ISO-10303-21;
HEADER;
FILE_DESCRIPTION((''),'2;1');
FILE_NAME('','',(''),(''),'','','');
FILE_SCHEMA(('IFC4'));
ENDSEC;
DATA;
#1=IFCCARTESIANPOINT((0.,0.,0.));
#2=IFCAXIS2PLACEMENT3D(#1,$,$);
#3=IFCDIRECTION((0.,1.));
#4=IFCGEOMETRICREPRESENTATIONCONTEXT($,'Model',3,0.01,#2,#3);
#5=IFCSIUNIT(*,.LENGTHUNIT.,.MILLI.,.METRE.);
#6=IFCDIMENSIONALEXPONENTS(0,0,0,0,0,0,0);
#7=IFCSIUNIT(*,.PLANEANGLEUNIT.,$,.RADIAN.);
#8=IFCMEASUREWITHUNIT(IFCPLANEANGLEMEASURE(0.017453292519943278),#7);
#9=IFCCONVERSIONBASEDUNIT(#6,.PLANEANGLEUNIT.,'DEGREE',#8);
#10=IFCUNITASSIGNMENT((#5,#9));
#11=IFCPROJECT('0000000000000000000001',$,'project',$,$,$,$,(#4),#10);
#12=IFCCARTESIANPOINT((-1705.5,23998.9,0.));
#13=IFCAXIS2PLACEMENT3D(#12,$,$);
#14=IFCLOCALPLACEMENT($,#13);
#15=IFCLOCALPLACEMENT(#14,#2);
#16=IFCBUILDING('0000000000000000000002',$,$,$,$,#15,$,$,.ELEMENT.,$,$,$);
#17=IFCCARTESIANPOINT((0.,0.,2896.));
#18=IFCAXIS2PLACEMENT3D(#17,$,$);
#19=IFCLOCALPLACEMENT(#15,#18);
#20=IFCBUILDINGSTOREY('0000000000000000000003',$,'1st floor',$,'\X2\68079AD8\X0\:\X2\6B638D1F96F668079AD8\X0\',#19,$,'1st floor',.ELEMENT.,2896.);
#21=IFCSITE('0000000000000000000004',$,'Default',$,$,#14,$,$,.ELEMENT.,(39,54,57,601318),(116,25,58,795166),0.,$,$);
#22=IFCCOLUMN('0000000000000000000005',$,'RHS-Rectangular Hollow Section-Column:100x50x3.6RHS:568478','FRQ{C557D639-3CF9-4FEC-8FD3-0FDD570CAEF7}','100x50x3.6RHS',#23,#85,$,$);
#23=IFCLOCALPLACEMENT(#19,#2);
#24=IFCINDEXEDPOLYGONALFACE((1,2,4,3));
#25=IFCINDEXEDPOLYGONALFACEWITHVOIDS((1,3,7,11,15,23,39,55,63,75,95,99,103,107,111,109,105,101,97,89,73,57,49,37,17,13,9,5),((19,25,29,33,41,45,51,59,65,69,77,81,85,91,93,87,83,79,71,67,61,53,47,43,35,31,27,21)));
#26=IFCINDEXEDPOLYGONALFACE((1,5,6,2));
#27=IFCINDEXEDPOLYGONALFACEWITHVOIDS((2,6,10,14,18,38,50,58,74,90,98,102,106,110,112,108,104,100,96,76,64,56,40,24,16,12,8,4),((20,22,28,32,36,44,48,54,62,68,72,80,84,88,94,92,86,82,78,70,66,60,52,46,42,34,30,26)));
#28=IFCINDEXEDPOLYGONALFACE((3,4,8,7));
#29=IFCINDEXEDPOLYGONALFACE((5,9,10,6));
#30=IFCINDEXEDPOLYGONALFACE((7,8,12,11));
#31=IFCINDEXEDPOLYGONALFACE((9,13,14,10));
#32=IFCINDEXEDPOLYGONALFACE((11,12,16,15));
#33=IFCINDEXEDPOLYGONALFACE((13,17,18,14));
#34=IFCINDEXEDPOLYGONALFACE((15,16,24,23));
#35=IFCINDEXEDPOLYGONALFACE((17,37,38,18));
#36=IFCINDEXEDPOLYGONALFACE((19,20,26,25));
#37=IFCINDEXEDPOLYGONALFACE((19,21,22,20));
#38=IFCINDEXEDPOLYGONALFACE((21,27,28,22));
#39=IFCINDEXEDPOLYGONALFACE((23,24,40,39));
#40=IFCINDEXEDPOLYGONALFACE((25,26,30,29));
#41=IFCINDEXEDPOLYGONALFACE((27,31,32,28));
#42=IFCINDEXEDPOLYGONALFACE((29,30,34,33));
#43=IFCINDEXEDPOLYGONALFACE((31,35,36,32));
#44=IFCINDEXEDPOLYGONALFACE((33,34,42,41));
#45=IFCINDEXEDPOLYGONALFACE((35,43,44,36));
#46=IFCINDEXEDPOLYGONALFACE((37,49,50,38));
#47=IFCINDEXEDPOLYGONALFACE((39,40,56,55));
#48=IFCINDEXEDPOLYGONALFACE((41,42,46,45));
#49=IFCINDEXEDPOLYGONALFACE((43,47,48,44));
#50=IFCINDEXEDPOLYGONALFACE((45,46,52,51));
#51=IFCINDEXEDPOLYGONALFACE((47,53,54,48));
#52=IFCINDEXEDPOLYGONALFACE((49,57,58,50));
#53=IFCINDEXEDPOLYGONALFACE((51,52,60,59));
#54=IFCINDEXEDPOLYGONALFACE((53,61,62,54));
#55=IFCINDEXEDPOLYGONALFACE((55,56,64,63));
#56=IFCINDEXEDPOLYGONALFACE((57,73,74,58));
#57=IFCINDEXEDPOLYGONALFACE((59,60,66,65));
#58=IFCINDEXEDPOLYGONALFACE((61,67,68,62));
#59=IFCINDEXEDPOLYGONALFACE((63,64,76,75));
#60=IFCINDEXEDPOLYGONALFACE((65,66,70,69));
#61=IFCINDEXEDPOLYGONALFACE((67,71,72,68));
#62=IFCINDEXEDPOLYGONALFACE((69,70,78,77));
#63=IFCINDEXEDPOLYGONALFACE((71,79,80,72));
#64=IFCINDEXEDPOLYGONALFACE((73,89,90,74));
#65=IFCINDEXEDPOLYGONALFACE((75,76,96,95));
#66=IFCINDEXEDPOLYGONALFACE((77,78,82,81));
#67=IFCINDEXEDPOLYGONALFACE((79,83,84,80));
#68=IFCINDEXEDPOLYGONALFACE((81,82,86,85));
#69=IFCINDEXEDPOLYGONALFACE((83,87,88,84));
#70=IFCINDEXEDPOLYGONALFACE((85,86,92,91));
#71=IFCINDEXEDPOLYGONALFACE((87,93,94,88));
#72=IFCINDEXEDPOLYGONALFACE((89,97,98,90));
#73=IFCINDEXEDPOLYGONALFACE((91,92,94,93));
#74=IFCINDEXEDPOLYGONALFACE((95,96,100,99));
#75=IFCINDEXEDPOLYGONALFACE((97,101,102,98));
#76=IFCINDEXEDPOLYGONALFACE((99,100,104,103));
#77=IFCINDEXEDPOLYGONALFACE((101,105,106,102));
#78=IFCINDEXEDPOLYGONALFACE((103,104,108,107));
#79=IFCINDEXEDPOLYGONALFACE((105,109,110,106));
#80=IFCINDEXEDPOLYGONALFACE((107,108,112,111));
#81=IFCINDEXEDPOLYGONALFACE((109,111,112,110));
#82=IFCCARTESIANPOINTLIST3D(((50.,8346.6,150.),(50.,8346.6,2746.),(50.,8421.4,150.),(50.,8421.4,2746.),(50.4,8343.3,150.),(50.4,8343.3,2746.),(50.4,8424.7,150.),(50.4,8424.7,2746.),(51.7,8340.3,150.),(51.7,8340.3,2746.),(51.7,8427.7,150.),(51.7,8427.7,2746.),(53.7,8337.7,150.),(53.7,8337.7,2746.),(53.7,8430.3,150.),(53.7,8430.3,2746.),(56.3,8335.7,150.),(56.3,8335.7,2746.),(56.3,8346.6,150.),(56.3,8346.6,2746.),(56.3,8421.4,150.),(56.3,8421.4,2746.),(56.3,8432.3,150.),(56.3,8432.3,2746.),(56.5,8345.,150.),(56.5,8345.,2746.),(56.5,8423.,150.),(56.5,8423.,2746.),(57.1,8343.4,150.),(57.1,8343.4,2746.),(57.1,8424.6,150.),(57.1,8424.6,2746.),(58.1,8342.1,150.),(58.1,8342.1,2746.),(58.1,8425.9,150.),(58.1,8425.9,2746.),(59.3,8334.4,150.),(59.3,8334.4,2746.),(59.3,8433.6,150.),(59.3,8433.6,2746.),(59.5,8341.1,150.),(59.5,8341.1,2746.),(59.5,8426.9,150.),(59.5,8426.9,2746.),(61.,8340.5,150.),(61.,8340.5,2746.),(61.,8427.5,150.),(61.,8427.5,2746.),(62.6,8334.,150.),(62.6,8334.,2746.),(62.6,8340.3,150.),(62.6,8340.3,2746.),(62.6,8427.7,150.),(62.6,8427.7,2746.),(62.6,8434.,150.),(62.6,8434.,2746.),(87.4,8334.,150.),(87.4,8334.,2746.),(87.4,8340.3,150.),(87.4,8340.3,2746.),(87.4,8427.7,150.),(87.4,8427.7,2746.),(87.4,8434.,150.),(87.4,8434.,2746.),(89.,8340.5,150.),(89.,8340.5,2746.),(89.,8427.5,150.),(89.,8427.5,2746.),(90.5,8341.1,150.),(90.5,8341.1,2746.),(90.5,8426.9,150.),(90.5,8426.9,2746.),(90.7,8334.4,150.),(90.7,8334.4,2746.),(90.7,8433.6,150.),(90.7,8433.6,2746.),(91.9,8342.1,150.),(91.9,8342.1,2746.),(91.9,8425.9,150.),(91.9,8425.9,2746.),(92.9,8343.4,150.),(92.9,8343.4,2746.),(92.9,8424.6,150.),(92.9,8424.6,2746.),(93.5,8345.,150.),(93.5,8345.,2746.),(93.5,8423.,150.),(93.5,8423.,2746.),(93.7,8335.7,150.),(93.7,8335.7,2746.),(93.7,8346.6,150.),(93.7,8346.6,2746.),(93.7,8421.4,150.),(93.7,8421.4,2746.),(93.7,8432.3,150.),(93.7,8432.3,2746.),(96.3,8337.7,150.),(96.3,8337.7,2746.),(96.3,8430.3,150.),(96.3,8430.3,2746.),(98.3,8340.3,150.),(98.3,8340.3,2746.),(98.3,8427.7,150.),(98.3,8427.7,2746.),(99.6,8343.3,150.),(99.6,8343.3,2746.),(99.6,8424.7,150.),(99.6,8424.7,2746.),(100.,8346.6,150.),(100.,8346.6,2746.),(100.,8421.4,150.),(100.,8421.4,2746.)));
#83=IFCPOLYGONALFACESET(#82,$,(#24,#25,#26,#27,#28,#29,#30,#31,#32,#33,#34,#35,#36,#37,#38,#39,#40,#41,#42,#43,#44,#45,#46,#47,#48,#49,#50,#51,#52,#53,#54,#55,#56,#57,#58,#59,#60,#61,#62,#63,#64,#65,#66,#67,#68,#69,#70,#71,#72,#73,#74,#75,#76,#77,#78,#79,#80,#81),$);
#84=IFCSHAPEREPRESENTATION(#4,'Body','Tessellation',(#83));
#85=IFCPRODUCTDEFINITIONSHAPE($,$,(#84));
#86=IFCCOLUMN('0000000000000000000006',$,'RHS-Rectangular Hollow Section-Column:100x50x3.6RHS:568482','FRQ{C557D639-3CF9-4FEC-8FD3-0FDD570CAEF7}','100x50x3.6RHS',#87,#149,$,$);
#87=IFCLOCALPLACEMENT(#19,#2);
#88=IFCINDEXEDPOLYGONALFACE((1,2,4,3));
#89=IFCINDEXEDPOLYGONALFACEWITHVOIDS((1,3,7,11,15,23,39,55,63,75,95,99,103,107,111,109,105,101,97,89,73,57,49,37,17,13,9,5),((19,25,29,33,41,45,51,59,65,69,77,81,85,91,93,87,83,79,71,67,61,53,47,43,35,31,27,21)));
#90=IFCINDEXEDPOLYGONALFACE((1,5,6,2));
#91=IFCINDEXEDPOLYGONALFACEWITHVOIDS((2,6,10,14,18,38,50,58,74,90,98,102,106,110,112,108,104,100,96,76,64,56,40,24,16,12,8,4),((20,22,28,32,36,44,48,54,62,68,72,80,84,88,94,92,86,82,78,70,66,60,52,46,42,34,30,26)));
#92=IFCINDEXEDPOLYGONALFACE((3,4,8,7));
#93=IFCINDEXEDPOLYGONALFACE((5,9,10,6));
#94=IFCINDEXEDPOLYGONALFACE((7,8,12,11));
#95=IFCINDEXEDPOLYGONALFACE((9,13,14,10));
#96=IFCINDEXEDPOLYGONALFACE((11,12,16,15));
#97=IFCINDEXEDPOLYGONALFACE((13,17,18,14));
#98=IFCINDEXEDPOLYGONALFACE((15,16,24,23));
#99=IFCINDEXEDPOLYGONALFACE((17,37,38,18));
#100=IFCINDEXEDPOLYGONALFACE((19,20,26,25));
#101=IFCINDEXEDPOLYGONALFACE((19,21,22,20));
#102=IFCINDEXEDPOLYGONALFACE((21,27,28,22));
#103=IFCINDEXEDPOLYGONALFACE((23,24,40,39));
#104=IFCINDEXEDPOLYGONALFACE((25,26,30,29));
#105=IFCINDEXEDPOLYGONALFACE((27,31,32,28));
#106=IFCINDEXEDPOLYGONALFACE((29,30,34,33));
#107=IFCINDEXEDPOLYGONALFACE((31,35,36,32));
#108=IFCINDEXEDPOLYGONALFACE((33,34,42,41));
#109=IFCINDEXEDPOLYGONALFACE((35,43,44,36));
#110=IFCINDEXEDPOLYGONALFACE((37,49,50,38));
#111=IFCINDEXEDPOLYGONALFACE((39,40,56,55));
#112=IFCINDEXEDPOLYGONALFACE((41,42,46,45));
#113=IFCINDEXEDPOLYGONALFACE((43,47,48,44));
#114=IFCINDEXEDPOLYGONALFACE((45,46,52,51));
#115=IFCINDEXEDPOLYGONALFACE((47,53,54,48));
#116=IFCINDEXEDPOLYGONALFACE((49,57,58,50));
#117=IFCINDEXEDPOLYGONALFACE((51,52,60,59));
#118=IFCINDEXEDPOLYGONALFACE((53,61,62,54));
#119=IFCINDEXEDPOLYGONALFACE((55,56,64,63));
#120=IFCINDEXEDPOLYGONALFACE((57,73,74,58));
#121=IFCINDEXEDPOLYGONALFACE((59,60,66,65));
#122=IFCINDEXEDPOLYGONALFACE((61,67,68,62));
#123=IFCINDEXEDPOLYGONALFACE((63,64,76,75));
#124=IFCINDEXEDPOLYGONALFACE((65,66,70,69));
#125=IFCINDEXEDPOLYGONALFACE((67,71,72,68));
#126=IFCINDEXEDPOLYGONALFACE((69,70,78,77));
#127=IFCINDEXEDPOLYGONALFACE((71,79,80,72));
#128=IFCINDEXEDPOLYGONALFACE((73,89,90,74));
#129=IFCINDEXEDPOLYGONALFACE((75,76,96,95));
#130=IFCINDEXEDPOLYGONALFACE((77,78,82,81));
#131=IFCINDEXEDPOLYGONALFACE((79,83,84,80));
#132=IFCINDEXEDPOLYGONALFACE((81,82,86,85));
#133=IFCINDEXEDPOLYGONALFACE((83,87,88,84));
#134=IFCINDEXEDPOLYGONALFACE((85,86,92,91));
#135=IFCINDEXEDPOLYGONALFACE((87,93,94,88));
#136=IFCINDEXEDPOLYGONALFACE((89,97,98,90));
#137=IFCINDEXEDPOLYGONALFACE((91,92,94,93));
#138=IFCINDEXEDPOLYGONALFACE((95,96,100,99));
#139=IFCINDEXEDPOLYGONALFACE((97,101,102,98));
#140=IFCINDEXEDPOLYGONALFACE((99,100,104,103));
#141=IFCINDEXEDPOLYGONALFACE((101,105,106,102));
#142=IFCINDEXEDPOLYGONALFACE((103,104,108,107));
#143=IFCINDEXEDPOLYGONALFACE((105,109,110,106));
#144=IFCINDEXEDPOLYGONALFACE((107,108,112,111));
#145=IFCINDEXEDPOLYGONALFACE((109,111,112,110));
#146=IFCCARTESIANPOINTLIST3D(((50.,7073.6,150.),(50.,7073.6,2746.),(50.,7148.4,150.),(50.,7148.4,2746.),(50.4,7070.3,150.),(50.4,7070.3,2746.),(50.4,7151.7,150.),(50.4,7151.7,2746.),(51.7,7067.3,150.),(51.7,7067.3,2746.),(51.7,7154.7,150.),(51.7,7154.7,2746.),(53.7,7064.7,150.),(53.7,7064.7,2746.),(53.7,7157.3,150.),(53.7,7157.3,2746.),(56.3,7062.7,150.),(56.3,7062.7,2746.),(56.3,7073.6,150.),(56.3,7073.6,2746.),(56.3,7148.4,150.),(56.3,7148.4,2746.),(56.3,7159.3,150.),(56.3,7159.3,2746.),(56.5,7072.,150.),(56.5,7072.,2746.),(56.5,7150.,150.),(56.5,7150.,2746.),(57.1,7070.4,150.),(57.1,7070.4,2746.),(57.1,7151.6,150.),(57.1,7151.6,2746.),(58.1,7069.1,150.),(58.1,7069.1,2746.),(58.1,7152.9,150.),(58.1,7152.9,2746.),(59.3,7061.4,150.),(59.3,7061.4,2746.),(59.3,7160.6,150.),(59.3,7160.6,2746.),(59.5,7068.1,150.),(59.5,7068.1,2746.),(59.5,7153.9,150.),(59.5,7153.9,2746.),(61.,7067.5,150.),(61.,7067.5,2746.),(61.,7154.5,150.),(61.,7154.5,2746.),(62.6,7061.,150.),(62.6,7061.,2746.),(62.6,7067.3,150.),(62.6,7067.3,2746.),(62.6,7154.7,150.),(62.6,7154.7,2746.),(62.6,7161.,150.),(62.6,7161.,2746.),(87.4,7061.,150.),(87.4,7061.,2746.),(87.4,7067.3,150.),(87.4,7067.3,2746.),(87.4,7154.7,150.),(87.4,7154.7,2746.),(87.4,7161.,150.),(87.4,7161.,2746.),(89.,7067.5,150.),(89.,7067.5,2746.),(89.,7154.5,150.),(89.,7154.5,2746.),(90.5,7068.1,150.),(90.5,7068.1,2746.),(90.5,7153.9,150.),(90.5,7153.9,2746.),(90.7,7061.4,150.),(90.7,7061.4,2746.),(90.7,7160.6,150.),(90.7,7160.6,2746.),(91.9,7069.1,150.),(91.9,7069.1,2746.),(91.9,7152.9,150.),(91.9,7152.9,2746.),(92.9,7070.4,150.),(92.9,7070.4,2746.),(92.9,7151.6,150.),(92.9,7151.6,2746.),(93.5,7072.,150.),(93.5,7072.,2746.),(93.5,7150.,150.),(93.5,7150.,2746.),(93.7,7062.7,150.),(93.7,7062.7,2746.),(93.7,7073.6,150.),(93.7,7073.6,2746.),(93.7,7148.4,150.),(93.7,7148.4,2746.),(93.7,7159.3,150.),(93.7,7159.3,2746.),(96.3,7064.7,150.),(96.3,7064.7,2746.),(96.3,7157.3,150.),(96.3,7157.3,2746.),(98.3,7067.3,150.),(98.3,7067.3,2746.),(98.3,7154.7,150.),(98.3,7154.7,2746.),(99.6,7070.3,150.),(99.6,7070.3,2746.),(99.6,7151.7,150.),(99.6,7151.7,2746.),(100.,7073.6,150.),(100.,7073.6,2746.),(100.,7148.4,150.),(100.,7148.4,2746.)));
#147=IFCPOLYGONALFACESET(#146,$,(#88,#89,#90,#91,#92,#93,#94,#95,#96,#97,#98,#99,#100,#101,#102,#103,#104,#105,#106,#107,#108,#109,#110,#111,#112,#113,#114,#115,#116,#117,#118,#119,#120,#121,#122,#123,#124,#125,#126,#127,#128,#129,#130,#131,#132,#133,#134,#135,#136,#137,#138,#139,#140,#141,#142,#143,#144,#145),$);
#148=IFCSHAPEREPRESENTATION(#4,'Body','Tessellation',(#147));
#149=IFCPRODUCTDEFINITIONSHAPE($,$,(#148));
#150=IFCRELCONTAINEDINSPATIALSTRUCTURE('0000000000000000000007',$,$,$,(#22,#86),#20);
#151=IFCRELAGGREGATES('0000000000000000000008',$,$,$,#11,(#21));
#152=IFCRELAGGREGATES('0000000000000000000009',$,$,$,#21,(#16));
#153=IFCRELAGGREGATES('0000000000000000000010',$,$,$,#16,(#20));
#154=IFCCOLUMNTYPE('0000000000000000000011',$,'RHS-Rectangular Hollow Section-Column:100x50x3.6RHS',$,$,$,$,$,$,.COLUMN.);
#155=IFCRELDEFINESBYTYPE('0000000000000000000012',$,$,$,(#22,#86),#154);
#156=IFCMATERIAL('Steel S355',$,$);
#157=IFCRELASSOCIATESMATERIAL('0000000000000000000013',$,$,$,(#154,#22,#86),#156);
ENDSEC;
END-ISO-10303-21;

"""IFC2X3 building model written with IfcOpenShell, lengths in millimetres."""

from ifc_helpers import new_model, entity, si_unit, converted_unit, point, direction, frame, frame_2d, origin, origin_2d, place, context, project, spatial, circle_curve, line_curve, trimmed, segment, composite_curve, hollow_rectangle, outline, extrude, clip, halfspace, material, type_object, element, save


model = new_model("IFC2X3")

# Units and contexts
model_context = context("Model", 3, precision=0.01, world=origin(), true_north=direction((0.0, 1.0)))
ifc_project = project(units=[si_unit("LENGTHUNIT", "METRE", prefix="MILLI"), converted_unit("PLANEANGLEUNIT", "DEGREE", entity("IfcPlaneAngleMeasure", 0.017453292519943278), si_unit("PLANEANGLEUNIT", "RADIAN"), dimensions=[0, 0, 0, 0, 0, 0, 0])], contexts=[model_context])

# Site, building, storey
site_placement = place(None, frame((-1705.5, 23998.9, 0.0)))
site = spatial("IfcSite", under=ifc_project, at=site_placement, Name="Default", CompositionType="ELEMENT", RefLatitude=(39, 54, 57, 601318), RefLongitude=(116, 25, 58, 795166), RefElevation=0.0)
building_placement = place(site_placement, origin())
building = spatial("IfcBuilding", under=site, at=building_placement, CompositionType="ELEMENT")
storey_placement = place(building_placement, frame((0.0, 0.0, 2896.0)))
storey = spatial("IfcBuildingStorey", under=building, at=storey_placement, Name="1st floor", ObjectType="标高:正负零标高", LongName="1st floor", CompositionType="ELEMENT", Elevation=2896.0)

# Columns, openings
ifc_material_1 = material(Name="Steel S355")
column_type = type_object("IfcColumnType", Name="RHS-Rectangular Hollow Section-Column:100x50x3.6RHS", PredefinedType="COLUMN", material=ifc_material_1)
column_1_placement = place(storey_placement, frame((75.0, 8384.0, 2876.9)))
column_1 = element("IfcColumn", 1, at=column_1_placement, inside=storey, type_object=column_type, material=ifc_material_1, Name="RHS-Rectangular Hollow Section-Column:100x50x3.6RHS:568478", Description="FRQ{C557D639-3CF9-4FEC-8FD3-0FDD570CAEF7}", ObjectType="100x50x3.6RHS", context=model_context, shape_type="Clipping", body=[
    clip(clip(extrude(hollow_rectangle(XDim=50.0, YDim=100.0, WallThickness=6.3, InnerFilletRadius=6.3, OuterFilletRadius=12.6, at=origin_2d()), origin(), (0.0, 0.0, -1.0), 2782.8), halfspace(frame((-75.0, -8384.0, -55.9), z_axis=(0.0, 0.0, -1.0), x_axis=(-1.0, 0.0, 0.0)), True)), halfspace(frame((-75.0, -8384.0, -2726.9), z_axis=(0.0, 0.0, 1.0), x_axis=(1.0, 0.0, 0.0)), True)),
])
opening_1_placement = place(column_1_placement, frame((0.0, -150.1, -130.9), z_axis=(0.0, 1.0, 0.0), x_axis=(-1.0, 0.0, 0.0)))
element("IfcOpeningElement", 2, at=opening_1_placement, cuts=column_1, ObjectType="Opening", context=model_context, shape_type="SweptSolid", body=[
    extrude(outline(composite_curve([segment(trimmed(circle_curve(frame_2d((43.0, 32.0), x_axis=(1.0, 0.0)), 32.0), [point((43.0, 0.0))], [point((75.0, 32.0))], True, "CARTESIAN"), True, "CONTINUOUS"), segment(trimmed(line_curve((75.0, 32.0), (0.0, 1.0), 86.0), [point((75.0, 32.0))], [point((75.0, 118.0))], True, "CARTESIAN"), True, "CONTINUOUS"), segment(trimmed(circle_curve(frame_2d((43.0, 118.0), x_axis=(1.0, 0.0)), 32.0), [point((75.0, 118.0))], [point((43.0, 150.0))], True, "CARTESIAN"), True, "CONTINUOUS"), segment(trimmed(line_curve((43.0, 150.0), (-1.0, 0.0), 86.0), [point((43.0, 150.0))], [point((-43.0, 150.0))], True, "CARTESIAN"), True, "CONTINUOUS"), segment(trimmed(circle_curve(frame_2d((-43.0, 118.0), x_axis=(1.0, 0.0)), 32.0), [point((-43.0, 150.0))], [point((-75.0, 118.0))], True, "CARTESIAN"), True, "CONTINUOUS"), segment(trimmed(line_curve((-75.0, 118.0), (0.0, -1.0), 86.0), [point((-75.0, 118.0))], [point((-75.0, 32.0))], True, "CARTESIAN"), True, "CONTINUOUS"), segment(trimmed(circle_curve(frame_2d((-43.0, 32.0), x_axis=(1.0, 0.0)), 32.0), [point((-75.0, 32.0))], [point((-43.0, 0.0))], True, "CARTESIAN"), True, "CONTINUOUS"), segment(trimmed(line_curve((-43.0, 0.0), (1.0, 0.0), 86.0), [point((-43.0, 0.0))], [point((43.0, 0.0))], True, "CARTESIAN"), True, "CONTINUOUS")], self_intersect="UNKNOWN")), origin(), (0.0, 0.0, 1.0), 300.2),
])
column_2_placement = place(storey_placement, frame((75.0, 7111.0, 2876.9)))
column_2 = element("IfcColumn", 3, at=column_2_placement, inside=storey, type_object=column_type, material=ifc_material_1, Name="RHS-Rectangular Hollow Section-Column:100x50x3.6RHS:568482", Description="FRQ{C557D639-3CF9-4FEC-8FD3-0FDD570CAEF7}", ObjectType="100x50x3.6RHS", context=model_context, shape_type="Clipping", body=[
    clip(clip(extrude(hollow_rectangle(XDim=50.0, YDim=100.0, WallThickness=6.3, InnerFilletRadius=6.3, OuterFilletRadius=12.6, at=origin_2d()), origin(), (0.0, 0.0, -1.0), 2782.8), halfspace(frame((-75.0, -7111.0, -55.9), z_axis=(0.0, 0.0, -1.0), x_axis=(-1.0, 0.0, 0.0)), True)), halfspace(frame((-75.0, -7111.0, -2726.9), z_axis=(0.0, 0.0, 1.0), x_axis=(1.0, 0.0, 0.0)), True)),
])
opening_2_placement = place(column_2_placement, frame((0.0, -150.1, -130.9), z_axis=(0.0, 1.0, 0.0), x_axis=(-1.0, 0.0, 0.0)))
element("IfcOpeningElement", 4, at=opening_2_placement, cuts=column_2, ObjectType="Opening", context=model_context, shape_type="SweptSolid", body=[
    extrude(outline(composite_curve([segment(trimmed(circle_curve(frame_2d((43.0, 32.0), x_axis=(1.0, 0.0)), 32.0), [point((43.0, 0.0))], [point((75.0, 32.0))], True, "CARTESIAN"), True, "CONTINUOUS"), segment(trimmed(line_curve((75.0, 32.0), (0.0, 1.0), 86.0), [point((75.0, 32.0))], [point((75.0, 118.0))], True, "CARTESIAN"), True, "CONTINUOUS"), segment(trimmed(circle_curve(frame_2d((43.0, 118.0), x_axis=(1.0, 0.0)), 32.0), [point((75.0, 118.0))], [point((43.0, 150.0))], True, "CARTESIAN"), True, "CONTINUOUS"), segment(trimmed(line_curve((43.0, 150.0), (-1.0, 0.0), 86.0), [point((43.0, 150.0))], [point((-43.0, 150.0))], True, "CARTESIAN"), True, "CONTINUOUS"), segment(trimmed(circle_curve(frame_2d((-43.0, 118.0), x_axis=(1.0, 0.0)), 32.0), [point((-43.0, 150.0))], [point((-75.0, 118.0))], True, "CARTESIAN"), True, "CONTINUOUS"), segment(trimmed(line_curve((-75.0, 118.0), (0.0, -1.0), 86.0), [point((-75.0, 118.0))], [point((-75.0, 32.0))], True, "CARTESIAN"), True, "CONTINUOUS"), segment(trimmed(circle_curve(frame_2d((-43.0, 32.0), x_axis=(1.0, 0.0)), 32.0), [point((-75.0, 32.0))], [point((-43.0, 0.0))], True, "CARTESIAN"), True, "CONTINUOUS"), segment(trimmed(line_curve((-43.0, 0.0), (1.0, 0.0), 86.0), [point((-43.0, 0.0))], [point((43.0, 0.0))], True, "CARTESIAN"), True, "CONTINUOUS")], self_intersect="UNKNOWN")), origin(), (0.0, 0.0, 1.0), 300.2),
])

save(model, "model.ifc")
